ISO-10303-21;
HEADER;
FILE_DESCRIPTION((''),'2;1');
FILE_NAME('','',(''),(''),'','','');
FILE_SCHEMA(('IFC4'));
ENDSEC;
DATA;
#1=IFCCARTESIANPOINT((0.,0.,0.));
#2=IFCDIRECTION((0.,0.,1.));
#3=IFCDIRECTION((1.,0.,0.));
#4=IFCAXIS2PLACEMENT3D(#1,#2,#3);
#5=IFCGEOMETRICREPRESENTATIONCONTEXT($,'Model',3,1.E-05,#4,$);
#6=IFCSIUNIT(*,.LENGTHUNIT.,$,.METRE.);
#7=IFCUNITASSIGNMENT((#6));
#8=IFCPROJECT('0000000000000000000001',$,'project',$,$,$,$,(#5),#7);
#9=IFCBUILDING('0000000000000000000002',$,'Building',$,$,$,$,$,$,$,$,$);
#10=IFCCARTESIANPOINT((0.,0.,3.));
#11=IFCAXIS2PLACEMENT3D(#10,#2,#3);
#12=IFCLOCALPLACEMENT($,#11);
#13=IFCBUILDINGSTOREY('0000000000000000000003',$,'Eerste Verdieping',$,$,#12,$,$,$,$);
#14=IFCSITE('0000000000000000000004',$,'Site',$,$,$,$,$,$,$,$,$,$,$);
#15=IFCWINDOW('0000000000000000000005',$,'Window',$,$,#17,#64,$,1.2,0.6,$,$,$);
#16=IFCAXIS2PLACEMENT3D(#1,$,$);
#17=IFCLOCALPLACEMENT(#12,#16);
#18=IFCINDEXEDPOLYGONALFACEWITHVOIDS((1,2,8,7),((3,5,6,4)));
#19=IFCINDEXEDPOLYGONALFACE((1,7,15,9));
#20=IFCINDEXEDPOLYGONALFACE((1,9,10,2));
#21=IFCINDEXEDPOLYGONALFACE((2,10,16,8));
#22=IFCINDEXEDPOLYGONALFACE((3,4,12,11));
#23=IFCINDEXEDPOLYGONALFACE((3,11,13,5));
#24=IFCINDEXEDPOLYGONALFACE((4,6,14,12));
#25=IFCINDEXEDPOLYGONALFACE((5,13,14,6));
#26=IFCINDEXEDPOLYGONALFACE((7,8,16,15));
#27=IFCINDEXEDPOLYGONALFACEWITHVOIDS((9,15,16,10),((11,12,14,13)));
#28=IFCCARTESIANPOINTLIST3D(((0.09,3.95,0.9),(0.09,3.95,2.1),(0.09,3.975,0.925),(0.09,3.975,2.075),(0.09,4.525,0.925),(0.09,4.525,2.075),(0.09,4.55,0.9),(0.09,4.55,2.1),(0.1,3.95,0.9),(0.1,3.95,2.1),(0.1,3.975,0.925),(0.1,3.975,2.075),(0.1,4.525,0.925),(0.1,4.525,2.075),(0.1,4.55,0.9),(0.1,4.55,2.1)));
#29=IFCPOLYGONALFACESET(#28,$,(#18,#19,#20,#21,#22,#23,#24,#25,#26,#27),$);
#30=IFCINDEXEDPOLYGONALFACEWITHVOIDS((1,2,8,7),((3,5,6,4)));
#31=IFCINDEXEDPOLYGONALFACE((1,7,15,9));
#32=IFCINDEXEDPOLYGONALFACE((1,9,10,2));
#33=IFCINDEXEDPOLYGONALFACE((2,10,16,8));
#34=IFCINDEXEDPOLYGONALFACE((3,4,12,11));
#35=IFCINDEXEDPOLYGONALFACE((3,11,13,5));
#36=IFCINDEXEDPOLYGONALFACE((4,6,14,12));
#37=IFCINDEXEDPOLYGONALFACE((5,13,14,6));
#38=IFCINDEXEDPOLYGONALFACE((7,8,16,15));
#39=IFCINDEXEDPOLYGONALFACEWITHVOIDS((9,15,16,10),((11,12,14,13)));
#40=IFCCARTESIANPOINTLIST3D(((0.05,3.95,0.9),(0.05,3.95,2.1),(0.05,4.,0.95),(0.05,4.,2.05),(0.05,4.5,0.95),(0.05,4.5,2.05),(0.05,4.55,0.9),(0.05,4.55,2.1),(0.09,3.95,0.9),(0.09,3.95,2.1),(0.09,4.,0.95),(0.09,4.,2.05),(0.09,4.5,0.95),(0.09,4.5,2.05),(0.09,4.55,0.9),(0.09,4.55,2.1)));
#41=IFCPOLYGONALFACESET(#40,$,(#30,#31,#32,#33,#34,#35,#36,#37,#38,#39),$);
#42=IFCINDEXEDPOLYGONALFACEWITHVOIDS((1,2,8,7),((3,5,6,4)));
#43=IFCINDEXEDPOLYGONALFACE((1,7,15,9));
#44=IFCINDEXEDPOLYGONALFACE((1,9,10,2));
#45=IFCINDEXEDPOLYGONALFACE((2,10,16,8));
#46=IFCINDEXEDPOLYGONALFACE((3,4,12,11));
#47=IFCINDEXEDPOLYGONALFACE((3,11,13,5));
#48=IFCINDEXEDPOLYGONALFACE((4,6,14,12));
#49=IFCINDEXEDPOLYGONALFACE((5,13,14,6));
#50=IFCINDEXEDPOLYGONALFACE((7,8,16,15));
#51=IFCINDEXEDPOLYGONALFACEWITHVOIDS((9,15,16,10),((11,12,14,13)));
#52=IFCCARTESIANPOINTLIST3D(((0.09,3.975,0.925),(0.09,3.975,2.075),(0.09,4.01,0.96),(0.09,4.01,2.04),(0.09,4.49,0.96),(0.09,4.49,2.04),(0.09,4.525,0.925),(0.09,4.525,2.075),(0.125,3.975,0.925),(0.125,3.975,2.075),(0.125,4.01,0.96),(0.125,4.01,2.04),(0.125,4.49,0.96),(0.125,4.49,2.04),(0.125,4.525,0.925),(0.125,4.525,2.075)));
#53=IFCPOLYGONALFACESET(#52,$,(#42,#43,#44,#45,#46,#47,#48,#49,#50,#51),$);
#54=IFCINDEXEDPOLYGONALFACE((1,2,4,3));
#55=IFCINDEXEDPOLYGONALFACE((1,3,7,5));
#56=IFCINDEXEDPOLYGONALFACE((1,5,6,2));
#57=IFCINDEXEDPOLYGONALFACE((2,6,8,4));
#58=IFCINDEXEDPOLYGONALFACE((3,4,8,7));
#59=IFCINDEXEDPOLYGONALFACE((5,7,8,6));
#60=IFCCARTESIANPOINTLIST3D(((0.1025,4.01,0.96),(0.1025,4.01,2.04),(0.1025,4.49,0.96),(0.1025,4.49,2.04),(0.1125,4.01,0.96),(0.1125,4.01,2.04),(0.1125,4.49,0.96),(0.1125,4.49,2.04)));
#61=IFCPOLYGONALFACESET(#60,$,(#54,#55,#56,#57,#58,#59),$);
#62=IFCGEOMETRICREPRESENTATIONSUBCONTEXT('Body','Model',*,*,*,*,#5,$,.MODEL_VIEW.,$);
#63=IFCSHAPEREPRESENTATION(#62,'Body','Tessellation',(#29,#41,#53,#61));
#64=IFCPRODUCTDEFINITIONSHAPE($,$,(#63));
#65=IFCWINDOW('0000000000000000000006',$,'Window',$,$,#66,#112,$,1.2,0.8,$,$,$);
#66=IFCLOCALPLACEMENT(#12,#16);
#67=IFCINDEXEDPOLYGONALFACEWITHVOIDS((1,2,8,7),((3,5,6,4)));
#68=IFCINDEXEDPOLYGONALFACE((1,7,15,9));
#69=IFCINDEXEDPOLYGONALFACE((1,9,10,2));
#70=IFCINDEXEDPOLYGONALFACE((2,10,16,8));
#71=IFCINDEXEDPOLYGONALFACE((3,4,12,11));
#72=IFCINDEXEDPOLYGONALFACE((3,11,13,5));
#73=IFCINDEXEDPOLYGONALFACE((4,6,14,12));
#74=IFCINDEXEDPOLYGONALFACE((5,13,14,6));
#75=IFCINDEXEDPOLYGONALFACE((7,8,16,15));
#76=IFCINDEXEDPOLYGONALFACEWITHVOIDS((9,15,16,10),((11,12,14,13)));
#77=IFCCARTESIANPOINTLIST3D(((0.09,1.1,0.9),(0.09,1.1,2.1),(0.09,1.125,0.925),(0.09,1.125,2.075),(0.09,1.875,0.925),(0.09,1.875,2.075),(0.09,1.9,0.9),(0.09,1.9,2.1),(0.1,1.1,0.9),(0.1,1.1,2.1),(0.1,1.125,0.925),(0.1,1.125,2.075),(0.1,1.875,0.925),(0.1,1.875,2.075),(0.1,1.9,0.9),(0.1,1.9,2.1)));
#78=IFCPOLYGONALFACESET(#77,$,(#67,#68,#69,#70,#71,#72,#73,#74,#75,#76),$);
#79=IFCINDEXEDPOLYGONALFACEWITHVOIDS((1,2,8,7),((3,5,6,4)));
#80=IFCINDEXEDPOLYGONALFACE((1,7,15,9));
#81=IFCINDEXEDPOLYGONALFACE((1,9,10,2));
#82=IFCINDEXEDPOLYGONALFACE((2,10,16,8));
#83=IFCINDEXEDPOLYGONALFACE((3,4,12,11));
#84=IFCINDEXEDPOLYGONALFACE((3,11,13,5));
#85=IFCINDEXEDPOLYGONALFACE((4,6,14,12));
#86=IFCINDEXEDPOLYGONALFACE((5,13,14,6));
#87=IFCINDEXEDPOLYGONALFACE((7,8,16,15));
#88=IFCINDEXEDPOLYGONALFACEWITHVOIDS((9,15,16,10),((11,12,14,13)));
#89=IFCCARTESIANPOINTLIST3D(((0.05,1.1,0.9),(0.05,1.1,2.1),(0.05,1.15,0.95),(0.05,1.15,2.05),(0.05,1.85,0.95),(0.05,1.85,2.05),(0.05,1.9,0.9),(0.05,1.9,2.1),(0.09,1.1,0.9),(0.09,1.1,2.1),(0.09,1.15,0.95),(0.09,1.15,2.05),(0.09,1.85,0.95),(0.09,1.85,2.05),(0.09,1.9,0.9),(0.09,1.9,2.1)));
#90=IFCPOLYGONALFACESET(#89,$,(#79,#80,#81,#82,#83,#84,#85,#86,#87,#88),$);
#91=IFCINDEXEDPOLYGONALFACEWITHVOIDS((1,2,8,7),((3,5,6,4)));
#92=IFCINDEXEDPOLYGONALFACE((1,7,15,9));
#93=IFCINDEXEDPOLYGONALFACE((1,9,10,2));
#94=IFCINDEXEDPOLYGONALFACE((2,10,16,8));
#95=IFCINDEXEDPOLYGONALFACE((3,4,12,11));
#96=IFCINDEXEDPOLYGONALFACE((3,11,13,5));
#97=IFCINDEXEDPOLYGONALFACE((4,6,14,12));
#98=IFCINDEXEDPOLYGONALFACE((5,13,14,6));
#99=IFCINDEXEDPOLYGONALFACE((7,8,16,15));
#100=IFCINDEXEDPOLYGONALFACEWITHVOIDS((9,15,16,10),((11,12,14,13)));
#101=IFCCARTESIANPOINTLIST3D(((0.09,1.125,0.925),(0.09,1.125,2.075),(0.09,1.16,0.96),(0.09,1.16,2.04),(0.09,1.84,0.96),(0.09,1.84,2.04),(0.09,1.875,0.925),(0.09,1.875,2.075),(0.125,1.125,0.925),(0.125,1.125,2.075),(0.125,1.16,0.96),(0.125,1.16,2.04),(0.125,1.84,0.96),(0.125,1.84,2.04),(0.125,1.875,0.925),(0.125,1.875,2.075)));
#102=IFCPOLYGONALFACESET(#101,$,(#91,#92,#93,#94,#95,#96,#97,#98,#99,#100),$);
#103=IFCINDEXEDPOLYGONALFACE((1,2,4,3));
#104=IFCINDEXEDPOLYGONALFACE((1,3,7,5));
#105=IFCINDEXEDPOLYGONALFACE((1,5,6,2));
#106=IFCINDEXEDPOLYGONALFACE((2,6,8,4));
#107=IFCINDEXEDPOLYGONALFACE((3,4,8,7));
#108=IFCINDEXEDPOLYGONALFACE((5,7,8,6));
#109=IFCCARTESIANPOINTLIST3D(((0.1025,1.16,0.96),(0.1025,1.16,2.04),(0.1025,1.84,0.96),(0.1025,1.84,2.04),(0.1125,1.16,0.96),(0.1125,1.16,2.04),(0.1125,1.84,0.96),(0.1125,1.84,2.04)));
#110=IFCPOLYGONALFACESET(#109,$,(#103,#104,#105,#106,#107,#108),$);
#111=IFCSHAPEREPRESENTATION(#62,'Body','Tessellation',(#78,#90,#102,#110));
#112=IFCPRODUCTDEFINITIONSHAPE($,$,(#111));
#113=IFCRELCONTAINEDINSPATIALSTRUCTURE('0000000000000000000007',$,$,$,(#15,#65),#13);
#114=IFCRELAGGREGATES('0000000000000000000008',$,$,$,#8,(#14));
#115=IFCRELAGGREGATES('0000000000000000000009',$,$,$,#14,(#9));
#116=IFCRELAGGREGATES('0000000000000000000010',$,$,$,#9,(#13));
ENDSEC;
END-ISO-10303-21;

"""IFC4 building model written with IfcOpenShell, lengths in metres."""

from ifc_helpers import new_model, si_unit, frame, origin_with_axes, place, context, subcontext, project, spatial, line, indexed_curve, outline, extrude, element, save


model = new_model("IFC4")

# Units and contexts
model_context = context("Model", 3, precision=1e-05, world=origin_with_axes())
body_context = subcontext(model_context, "Body", "Model", "MODEL_VIEW")
ifc_project = project(units=[si_unit("LENGTHUNIT", "METRE")], contexts=[model_context])

# Site, building, storey
site = spatial("IfcSite", under=ifc_project, Name="Site")
building = spatial("IfcBuilding", under=site, Name="Building")
storey_placement = place(None, frame((0.0, 0.0, 3.0), z_axis=(0.0, 0.0, 1.0), x_axis=(1.0, 0.0, 0.0)))
storey = spatial("IfcBuildingStorey", under=building, at=storey_placement, Name="Eerste Verdieping")

# Windows
window_1_placement = place(storey_placement, frame((0.0, 4.55, 0.9), z_axis=(0.0, 0.0, 1.0), x_axis=(0.0, -1.0, 0.0)))
element("IfcWindow", 1, at=window_1_placement, inside=storey, Name="Window", OverallHeight=1.2, OverallWidth=0.6, context=body_context, shape_type="SweptSolid", body=[
    extrude(outline(indexed_curve([(0.0, 0.0), (0.6, 0.0), (0.6, 1.2), (0.0, 1.2)], segments=[line(1, 2, 3, 4, 1)]), holes=[indexed_curve([(0.025, 0.025), (0.575, 0.025), (0.575, 1.175), (0.025, 1.175)], segments=[line(1, 2, 3, 4, 1)])]), frame((0.0, 0.09, 0.0), z_axis=(0.0, -1.0, 0.0), x_axis=(1.0, 0.0, 0.0)), (0.0, 0.0, -1.0), 0.01),
    extrude(outline(indexed_curve([(0.0, 0.0), (0.6, 0.0), (0.6, 1.2), (0.0, 1.2)], segments=[line(1, 2, 3, 4, 1)]), holes=[indexed_curve([(0.05, 0.05), (0.55, 0.05), (0.55, 1.15), (0.05, 1.15)], segments=[line(1, 2, 3, 4, 1)])]), frame((0.0, 0.05, 0.0), z_axis=(0.0, -1.0, 0.0), x_axis=(1.0, 0.0, 0.0)), (0.0, 0.0, -1.0), 0.04),
    extrude(outline(indexed_curve([(0.0, 0.0), (0.55, 0.0), (0.55, 1.15), (0.0, 1.15)], segments=[line(1, 2, 3, 4, 1)]), holes=[indexed_curve([(0.035, 0.035), (0.515, 0.035), (0.515, 1.115), (0.035, 1.115)], segments=[line(1, 2, 3, 4, 1)])]), frame((0.025, 0.09, 0.025), z_axis=(0.0, -1.0, 0.0), x_axis=(1.0, 0.0, 0.0)), (0.0, 0.0, -1.0), 0.035),
    extrude(outline(indexed_curve([(0.035, 0.035), (0.515, 0.035), (0.515, 1.115), (0.035, 1.115)], segments=[line(1, 2, 3, 4, 1)])), frame((0.025, 0.1025, 0.025), z_axis=(0.0, -1.0, 0.0), x_axis=(1.0, 0.0, 0.0)), (0.0, 0.0, -1.0), 0.01),
])
window_2_placement = place(storey_placement, frame((0.0, 1.9, 0.9), z_axis=(0.0, 0.0, 1.0), x_axis=(0.0, -1.0, 0.0)))
element("IfcWindow", 2, at=window_2_placement, inside=storey, Name="Window", OverallHeight=1.2, OverallWidth=0.8, context=body_context, shape_type="SweptSolid", body=[
    extrude(outline(indexed_curve([(0.0, 0.0), (0.8, 0.0), (0.8, 1.2), (0.0, 1.2)], segments=[line(1, 2, 3, 4, 1)]), holes=[indexed_curve([(0.025, 0.025), (0.775, 0.025), (0.775, 1.175), (0.025, 1.175)], segments=[line(1, 2, 3, 4, 1)])]), frame((0.0, 0.09, 0.0), z_axis=(0.0, -1.0, 0.0), x_axis=(1.0, 0.0, 0.0)), (0.0, 0.0, -1.0), 0.01),
    extrude(outline(indexed_curve([(0.0, 0.0), (0.8, 0.0), (0.8, 1.2), (0.0, 1.2)], segments=[line(1, 2, 3, 4, 1)]), holes=[indexed_curve([(0.05, 0.05), (0.75, 0.05), (0.75, 1.15), (0.05, 1.15)], segments=[line(1, 2, 3, 4, 1)])]), frame((0.0, 0.05, 0.0), z_axis=(0.0, -1.0, 0.0), x_axis=(1.0, 0.0, 0.0)), (0.0, 0.0, -1.0), 0.04),
    extrude(outline(indexed_curve([(0.0, 0.0), (0.75, 0.0), (0.75, 1.15), (0.0, 1.15)], segments=[line(1, 2, 3, 4, 1)]), holes=[indexed_curve([(0.035, 0.035), (0.715, 0.035), (0.715, 1.115), (0.035, 1.115)], segments=[line(1, 2, 3, 4, 1)])]), frame((0.025, 0.09, 0.025), z_axis=(0.0, -1.0, 0.0), x_axis=(1.0, 0.0, 0.0)), (0.0, 0.0, -1.0), 0.035),
    extrude(outline(indexed_curve([(0.035, 0.035), (0.715, 0.035), (0.715, 1.115), (0.035, 1.115)], segments=[line(1, 2, 3, 4, 1)])), frame((0.025, 0.1025, 0.025), z_axis=(0.0, -1.0, 0.0), x_axis=(1.0, 0.0, 0.0)), (0.0, 0.0, -1.0), 0.01),
])

save(model, "model.ifc")
